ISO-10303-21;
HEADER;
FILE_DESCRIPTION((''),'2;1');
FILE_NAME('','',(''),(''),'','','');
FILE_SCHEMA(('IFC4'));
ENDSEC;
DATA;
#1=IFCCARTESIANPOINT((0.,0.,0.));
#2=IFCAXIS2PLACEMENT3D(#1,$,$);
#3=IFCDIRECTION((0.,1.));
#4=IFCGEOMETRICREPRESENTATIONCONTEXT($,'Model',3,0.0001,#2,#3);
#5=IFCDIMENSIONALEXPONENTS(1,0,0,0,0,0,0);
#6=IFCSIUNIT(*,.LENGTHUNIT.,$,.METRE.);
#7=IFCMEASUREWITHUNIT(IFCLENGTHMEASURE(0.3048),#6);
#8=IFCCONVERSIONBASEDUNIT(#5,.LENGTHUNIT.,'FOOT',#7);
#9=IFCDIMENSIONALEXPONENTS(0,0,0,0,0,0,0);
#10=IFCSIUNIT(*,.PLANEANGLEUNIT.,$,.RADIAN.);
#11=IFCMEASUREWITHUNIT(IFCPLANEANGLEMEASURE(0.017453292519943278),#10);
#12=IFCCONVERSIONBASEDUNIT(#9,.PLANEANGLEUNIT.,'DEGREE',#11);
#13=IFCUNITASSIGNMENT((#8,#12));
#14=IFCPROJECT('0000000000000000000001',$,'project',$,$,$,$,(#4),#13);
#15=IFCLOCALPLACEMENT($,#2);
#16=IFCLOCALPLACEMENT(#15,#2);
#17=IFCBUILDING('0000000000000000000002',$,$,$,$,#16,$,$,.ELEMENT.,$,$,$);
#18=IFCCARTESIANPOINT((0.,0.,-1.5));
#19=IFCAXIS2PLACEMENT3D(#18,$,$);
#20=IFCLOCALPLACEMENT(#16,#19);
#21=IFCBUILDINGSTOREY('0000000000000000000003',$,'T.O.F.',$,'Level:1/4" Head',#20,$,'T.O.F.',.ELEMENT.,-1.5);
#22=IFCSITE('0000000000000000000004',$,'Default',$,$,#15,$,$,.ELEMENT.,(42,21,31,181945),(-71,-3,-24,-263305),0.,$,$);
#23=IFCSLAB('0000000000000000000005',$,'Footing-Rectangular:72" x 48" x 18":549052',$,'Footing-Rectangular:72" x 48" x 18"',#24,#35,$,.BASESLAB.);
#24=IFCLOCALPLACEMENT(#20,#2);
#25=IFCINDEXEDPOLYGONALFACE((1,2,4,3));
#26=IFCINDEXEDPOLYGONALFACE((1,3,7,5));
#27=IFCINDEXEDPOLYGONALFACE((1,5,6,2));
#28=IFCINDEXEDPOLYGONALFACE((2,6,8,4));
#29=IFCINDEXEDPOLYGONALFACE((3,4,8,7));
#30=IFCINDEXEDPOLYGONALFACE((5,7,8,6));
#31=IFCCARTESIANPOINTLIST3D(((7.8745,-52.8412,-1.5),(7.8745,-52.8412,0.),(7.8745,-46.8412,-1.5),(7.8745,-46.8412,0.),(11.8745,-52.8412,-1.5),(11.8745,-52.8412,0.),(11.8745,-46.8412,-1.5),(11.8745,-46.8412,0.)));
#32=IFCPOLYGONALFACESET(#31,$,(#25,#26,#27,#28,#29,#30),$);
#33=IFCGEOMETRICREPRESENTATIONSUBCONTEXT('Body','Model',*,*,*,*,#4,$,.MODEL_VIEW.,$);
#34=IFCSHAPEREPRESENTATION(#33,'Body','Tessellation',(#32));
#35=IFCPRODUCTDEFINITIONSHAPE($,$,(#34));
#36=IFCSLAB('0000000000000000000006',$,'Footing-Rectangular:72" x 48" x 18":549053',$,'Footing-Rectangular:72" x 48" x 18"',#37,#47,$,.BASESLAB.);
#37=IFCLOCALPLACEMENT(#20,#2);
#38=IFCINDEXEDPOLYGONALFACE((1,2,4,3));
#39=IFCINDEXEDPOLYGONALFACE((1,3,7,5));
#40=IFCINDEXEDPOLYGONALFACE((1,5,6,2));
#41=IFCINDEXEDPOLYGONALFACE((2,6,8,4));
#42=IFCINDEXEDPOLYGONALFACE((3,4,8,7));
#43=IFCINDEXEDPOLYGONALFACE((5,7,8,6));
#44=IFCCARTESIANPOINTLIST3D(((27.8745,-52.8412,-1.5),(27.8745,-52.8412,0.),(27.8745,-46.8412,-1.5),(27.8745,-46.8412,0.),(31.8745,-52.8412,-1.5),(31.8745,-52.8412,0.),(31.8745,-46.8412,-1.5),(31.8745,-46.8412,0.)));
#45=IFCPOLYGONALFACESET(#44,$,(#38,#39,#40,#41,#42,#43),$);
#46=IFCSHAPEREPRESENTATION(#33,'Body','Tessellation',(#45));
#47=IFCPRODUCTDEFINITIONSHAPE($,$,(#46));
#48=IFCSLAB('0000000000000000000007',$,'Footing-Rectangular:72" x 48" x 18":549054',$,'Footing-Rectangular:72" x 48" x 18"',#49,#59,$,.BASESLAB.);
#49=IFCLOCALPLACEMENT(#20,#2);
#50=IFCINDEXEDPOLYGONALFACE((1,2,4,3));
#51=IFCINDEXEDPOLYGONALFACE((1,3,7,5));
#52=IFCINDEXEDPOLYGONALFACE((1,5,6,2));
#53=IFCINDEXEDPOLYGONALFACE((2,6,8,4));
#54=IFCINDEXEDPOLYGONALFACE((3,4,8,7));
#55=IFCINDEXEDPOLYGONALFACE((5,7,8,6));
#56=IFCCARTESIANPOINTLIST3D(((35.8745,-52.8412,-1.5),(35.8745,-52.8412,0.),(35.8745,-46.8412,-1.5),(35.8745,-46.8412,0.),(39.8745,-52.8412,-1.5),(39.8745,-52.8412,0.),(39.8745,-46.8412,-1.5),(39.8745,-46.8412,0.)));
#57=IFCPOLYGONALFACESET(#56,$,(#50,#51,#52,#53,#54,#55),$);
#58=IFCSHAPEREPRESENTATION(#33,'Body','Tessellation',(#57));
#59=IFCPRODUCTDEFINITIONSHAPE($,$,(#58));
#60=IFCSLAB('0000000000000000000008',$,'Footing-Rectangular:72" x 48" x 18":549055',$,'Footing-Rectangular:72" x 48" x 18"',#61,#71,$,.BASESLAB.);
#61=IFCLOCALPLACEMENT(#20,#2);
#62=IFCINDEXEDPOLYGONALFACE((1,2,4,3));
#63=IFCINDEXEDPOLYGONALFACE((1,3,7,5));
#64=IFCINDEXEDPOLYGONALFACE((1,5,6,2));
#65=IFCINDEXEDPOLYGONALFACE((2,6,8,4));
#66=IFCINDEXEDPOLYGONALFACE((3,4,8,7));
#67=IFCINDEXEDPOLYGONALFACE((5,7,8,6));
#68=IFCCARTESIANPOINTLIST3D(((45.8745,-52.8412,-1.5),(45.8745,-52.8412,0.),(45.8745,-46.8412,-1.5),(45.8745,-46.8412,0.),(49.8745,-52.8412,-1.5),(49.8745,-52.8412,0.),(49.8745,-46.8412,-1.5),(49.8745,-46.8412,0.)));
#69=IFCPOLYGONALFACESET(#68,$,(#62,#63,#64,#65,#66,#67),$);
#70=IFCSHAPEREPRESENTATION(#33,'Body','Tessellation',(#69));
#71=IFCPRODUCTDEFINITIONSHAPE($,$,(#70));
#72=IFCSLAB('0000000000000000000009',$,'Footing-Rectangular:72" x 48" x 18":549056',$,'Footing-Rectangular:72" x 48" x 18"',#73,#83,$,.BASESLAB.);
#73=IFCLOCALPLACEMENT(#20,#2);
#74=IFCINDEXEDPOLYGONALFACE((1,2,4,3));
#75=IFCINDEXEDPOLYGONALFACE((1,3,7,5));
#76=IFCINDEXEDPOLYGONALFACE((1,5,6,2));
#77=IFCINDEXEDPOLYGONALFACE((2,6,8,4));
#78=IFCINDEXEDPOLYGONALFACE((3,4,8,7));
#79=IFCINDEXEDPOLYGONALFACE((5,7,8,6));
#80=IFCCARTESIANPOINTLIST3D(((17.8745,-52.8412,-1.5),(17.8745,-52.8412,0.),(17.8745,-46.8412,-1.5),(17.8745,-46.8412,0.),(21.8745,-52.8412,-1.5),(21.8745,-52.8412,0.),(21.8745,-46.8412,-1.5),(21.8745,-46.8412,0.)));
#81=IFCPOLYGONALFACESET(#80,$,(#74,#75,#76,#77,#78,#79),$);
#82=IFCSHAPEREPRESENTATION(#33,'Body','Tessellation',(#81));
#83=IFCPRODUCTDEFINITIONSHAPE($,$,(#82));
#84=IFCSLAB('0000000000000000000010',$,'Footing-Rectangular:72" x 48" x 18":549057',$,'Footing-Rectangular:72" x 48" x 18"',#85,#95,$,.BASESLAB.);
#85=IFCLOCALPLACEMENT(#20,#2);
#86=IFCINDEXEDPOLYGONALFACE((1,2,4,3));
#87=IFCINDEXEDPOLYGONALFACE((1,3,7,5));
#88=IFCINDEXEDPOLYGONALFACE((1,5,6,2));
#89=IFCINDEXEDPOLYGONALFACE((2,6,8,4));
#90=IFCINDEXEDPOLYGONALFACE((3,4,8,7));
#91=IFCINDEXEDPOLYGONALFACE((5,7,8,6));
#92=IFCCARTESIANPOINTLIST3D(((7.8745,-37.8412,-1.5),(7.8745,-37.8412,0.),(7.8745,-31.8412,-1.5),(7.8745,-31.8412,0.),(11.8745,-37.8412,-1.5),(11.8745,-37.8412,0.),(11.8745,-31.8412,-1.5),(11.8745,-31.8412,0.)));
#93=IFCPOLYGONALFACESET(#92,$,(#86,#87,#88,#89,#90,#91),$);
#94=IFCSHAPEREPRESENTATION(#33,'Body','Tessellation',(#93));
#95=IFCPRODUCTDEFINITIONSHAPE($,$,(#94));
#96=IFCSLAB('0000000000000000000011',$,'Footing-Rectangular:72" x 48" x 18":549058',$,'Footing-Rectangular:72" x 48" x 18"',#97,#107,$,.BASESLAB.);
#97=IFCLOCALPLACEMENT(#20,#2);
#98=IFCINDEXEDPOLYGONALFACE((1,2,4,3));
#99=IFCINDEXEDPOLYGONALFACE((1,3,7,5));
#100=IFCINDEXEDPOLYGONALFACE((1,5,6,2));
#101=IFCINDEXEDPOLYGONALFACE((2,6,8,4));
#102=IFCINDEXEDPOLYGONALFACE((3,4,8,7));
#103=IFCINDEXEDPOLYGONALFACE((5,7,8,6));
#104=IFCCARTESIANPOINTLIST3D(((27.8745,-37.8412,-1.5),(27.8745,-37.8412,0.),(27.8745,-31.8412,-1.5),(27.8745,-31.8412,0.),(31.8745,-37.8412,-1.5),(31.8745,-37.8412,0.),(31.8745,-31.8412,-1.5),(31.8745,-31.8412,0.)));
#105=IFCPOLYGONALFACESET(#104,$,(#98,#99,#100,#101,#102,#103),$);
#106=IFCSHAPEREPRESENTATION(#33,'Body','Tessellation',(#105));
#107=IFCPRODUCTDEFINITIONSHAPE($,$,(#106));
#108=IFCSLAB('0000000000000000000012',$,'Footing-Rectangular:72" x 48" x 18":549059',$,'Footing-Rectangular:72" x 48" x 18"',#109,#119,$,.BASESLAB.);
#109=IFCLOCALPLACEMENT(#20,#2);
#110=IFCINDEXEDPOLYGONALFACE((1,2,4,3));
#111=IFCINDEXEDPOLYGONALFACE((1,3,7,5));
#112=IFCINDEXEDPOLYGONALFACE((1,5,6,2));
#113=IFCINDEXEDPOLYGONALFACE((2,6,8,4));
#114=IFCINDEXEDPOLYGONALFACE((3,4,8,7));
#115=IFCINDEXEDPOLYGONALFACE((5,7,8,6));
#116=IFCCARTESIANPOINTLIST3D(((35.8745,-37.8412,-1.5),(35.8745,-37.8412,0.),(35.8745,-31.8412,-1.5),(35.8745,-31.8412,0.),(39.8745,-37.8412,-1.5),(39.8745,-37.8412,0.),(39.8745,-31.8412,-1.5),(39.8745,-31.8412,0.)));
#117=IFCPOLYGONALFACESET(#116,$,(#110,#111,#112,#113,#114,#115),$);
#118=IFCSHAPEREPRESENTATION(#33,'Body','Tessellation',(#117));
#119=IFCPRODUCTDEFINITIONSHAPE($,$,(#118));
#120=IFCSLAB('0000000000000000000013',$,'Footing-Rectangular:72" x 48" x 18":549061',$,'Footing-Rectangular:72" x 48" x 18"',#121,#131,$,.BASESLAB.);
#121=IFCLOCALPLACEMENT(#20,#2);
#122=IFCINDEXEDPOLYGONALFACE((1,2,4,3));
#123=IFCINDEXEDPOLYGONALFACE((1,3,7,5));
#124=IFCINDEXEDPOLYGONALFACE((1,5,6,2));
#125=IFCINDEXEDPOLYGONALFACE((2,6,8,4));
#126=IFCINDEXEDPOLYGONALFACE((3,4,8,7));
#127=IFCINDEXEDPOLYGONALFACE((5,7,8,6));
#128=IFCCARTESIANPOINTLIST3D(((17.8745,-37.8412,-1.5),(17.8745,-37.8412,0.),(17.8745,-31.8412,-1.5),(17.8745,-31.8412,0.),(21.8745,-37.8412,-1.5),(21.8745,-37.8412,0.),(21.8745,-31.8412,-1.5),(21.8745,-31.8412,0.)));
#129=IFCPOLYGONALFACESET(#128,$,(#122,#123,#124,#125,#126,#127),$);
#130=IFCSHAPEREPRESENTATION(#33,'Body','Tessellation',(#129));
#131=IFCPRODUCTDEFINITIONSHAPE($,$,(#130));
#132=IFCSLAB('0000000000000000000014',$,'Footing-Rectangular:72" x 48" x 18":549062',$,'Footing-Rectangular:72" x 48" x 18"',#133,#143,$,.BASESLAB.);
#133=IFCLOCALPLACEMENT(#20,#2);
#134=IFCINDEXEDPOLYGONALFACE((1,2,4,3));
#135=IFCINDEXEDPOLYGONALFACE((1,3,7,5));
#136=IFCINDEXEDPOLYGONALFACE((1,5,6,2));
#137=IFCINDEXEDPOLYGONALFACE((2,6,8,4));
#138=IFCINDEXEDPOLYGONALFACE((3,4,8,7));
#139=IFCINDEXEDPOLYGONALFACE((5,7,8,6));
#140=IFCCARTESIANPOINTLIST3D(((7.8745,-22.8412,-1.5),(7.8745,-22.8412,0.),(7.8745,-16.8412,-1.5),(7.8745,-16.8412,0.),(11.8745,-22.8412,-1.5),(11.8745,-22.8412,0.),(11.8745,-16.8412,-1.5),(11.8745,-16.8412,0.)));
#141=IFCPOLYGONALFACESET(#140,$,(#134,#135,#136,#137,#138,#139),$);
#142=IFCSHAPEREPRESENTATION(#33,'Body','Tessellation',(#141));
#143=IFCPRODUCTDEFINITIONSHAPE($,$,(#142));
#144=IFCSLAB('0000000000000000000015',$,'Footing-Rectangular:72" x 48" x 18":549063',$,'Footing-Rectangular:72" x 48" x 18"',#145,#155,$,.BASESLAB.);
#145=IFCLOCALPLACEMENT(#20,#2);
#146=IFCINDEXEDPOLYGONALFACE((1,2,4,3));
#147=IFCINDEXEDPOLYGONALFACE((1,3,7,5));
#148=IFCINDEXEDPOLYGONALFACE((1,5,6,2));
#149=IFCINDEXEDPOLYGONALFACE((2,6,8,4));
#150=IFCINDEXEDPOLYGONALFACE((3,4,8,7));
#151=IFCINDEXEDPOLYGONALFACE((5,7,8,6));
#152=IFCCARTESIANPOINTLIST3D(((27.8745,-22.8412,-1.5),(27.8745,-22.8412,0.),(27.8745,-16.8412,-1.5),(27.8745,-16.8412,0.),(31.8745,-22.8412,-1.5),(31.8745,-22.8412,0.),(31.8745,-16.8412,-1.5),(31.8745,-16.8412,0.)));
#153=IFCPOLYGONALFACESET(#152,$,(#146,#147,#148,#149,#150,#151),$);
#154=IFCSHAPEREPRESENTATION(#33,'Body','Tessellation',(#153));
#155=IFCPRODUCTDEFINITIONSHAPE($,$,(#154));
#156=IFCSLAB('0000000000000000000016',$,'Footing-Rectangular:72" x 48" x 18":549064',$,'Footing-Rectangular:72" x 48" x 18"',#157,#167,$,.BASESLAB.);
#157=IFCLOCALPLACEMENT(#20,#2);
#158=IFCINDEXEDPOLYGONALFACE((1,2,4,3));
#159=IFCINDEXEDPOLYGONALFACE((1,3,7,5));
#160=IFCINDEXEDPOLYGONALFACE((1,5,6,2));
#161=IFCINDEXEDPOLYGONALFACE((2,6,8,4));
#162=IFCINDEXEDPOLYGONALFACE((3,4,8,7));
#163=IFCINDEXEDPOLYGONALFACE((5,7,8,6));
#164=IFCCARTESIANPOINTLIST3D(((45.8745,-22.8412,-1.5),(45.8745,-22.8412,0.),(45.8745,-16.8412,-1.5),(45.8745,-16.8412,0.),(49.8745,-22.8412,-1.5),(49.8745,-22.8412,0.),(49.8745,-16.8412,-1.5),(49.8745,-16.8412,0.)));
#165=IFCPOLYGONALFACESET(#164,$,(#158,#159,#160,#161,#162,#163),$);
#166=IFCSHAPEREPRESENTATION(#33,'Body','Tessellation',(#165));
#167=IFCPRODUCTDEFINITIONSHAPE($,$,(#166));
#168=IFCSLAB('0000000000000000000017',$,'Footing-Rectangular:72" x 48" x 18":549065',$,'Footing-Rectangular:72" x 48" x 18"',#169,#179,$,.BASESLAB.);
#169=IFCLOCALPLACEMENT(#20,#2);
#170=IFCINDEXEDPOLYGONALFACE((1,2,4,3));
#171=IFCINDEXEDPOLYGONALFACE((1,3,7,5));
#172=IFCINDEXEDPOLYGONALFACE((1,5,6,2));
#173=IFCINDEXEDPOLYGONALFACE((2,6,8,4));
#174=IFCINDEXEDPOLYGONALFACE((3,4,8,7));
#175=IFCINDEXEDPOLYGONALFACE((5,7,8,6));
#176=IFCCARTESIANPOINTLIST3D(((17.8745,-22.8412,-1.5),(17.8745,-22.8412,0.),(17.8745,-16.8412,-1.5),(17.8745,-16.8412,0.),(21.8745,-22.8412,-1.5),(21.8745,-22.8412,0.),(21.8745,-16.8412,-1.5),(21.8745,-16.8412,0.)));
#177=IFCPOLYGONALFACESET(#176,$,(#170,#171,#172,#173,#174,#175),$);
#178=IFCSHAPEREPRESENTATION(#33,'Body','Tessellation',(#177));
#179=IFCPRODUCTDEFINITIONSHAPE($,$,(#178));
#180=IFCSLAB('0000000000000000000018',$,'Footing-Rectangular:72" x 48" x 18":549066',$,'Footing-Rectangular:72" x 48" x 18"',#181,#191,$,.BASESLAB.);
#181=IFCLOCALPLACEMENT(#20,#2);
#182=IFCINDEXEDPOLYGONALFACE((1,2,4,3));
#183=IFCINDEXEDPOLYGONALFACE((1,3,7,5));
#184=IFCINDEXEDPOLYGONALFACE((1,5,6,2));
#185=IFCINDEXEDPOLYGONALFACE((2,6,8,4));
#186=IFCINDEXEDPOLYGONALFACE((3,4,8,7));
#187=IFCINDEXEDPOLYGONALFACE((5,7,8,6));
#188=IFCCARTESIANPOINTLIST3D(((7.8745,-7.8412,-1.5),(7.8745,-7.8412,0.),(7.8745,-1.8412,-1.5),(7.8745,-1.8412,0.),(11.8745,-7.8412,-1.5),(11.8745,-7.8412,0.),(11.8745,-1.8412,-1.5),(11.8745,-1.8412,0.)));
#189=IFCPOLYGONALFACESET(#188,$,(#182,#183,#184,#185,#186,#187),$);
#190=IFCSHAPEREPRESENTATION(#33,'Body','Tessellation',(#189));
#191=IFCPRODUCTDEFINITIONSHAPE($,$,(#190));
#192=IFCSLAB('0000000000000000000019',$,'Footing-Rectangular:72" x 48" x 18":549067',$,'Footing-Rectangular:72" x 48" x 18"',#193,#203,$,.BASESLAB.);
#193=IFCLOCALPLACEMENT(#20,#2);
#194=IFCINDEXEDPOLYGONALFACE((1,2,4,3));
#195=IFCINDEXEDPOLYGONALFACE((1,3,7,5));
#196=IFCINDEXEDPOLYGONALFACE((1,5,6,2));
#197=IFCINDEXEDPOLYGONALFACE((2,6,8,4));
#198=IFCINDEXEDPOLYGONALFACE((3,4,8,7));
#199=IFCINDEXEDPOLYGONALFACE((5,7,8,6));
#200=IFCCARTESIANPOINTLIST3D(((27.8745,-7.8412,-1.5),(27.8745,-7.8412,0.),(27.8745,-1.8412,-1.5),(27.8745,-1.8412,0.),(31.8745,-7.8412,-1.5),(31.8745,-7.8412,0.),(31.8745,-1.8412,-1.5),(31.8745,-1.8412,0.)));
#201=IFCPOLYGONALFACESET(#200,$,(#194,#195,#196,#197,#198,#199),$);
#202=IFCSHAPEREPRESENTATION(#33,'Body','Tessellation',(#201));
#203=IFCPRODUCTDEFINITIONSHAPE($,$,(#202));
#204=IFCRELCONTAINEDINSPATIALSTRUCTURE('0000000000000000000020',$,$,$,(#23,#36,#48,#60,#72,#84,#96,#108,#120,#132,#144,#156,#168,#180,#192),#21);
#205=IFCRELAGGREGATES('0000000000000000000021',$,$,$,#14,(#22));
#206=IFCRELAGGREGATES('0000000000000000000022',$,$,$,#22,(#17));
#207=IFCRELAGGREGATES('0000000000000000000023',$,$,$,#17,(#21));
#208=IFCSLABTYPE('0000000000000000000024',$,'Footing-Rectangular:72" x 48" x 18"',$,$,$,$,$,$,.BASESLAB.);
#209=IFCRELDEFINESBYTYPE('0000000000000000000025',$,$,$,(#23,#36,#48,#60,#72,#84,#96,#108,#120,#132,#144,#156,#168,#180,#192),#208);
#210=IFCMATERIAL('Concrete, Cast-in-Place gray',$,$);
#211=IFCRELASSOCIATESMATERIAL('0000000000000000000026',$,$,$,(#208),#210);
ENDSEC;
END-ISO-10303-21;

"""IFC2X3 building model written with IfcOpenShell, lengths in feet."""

from ifc_helpers import new_model, entity, si_unit, converted_unit, direction, frame, frame_2d, origin, origin_2d_with_axis, place, context, subcontext, project, spatial, rectangle, extrude, material, type_object, element, save


model = new_model("IFC2X3")

# Units and contexts
model_context = context("Model", 3, precision=0.0001, world=origin(), true_north=direction((0.0, 1.0)))
body_context = subcontext(model_context, "Body", "Model", "MODEL_VIEW")
ifc_project = project(units=[converted_unit("LENGTHUNIT", "FOOT", entity("IfcLengthMeasure", 0.3048), si_unit("LENGTHUNIT", "METRE"), dimensions=[1, 0, 0, 0, 0, 0, 0]), converted_unit("PLANEANGLEUNIT", "DEGREE", entity("IfcPlaneAngleMeasure", 0.017453292519943278), si_unit("PLANEANGLEUNIT", "RADIAN"), dimensions=[0, 0, 0, 0, 0, 0, 0])], contexts=[model_context])

# Site, building, storey
site_placement = place(None, origin())
site = spatial("IfcSite", under=ifc_project, at=site_placement, Name="Default", CompositionType="ELEMENT", RefLatitude=(42, 21, 31, 181945), RefLongitude=(-71, -3, -24, -263305), RefElevation=0.0)
building_placement = place(site_placement, origin())
building = spatial("IfcBuilding", under=site, at=building_placement, CompositionType="ELEMENT")
storey_placement = place(building_placement, frame((0.0, 0.0, -1.5)))
storey = spatial("IfcBuildingStorey", under=building, at=storey_placement, Name="T.O.F.", ObjectType="Level:1/4\" Head", LongName="T.O.F.", CompositionType="ELEMENT", Elevation=-1.5)

# Slabs
ifc_material = material(Name="Concrete, Cast-in-Place gray")
slab_type = type_object("IfcSlabType", Name="Footing-Rectangular:72\" x 48\" x 18\"", PredefinedType="BASESLAB", material=ifc_material)
slab_1_placement = place(storey_placement, origin())
element("IfcSlab", 1, at=slab_1_placement, inside=storey, type_object=slab_type, Name="Footing-Rectangular:72\" x 48\" x 18\":549052", ObjectType="Footing-Rectangular:72\" x 48\" x 18\"", PredefinedType="BASESLAB", context=body_context, shape_type="SweptSolid", body=[
    extrude(rectangle(XDim=4.0, YDim=6.0, at=origin_2d_with_axis()), frame((9.8745, -49.8412, -1.5), z_axis=(0.0, 0.0, 1.0), x_axis=(-1.0, 0.0, 0.0)), (0.0, 0.0, 1.0), 1.5),
])
slab_2_placement = place(storey_placement, origin())
element("IfcSlab", 2, at=slab_2_placement, inside=storey, type_object=slab_type, Name="Footing-Rectangular:72\" x 48\" x 18\":549053", ObjectType="Footing-Rectangular:72\" x 48\" x 18\"", PredefinedType="BASESLAB", context=body_context, shape_type="SweptSolid", body=[
    extrude(rectangle(XDim=4.0, YDim=6.0, at=frame_2d((0.0, 0.0), x_axis=(1.0, 0.0))), frame((29.8745, -49.8412, -1.5), z_axis=(0.0, 0.0, 1.0), x_axis=(-1.0, 0.0, 0.0)), (0.0, 0.0, 1.0), 1.5),
])
slab_3_placement = place(storey_placement, origin())
element("IfcSlab", 3, at=slab_3_placement, inside=storey, type_object=slab_type, Name="Footing-Rectangular:72\" x 48\" x 18\":549054", ObjectType="Footing-Rectangular:72\" x 48\" x 18\"", PredefinedType="BASESLAB", context=body_context, shape_type="SweptSolid", body=[
    extrude(rectangle(XDim=4.0, YDim=6.0, at=frame_2d((0.0, 0.0), x_axis=(1.0, 0.0))), frame((37.8745, -49.8412, -1.5), z_axis=(0.0, 0.0, 1.0), x_axis=(-1.0, 0.0, 0.0)), (0.0, 0.0, 1.0), 1.5),
])
slab_4_placement = place(storey_placement, origin())
element("IfcSlab", 4, at=slab_4_placement, inside=storey, type_object=slab_type, Name="Footing-Rectangular:72\" x 48\" x 18\":549055", ObjectType="Footing-Rectangular:72\" x 48\" x 18\"", PredefinedType="BASESLAB", context=body_context, shape_type="SweptSolid", body=[
    extrude(rectangle(XDim=4.0, YDim=6.0, at=frame_2d((0.0, 0.0), x_axis=(1.0, 0.0))), frame((47.8745, -49.8412, -1.5), z_axis=(0.0, 0.0, 1.0), x_axis=(-1.0, 0.0, 0.0)), (0.0, 0.0, 1.0), 1.5),
])
slab_5_placement = place(storey_placement, origin())
element("IfcSlab", 5, at=slab_5_placement, inside=storey, type_object=slab_type, Name="Footing-Rectangular:72\" x 48\" x 18\":549056", ObjectType="Footing-Rectangular:72\" x 48\" x 18\"", PredefinedType="BASESLAB", context=body_context, shape_type="SweptSolid", body=[
    extrude(rectangle(XDim=4.0, YDim=6.0, at=frame_2d((0.0, 0.0), x_axis=(1.0, 0.0))), frame((19.8745, -49.8412, -1.5), z_axis=(0.0, 0.0, 1.0), x_axis=(-1.0, 0.0, 0.0)), (0.0, 0.0, 1.0), 1.5),
])
slab_6_placement = place(storey_placement, origin())
element("IfcSlab", 6, at=slab_6_placement, inside=storey, type_object=slab_type, Name="Footing-Rectangular:72\" x 48\" x 18\":549057", ObjectType="Footing-Rectangular:72\" x 48\" x 18\"", PredefinedType="BASESLAB", context=body_context, shape_type="SweptSolid", body=[
    extrude(rectangle(XDim=4.0, YDim=6.0, at=origin_2d_with_axis()), frame((9.8745, -34.8412, -1.5), z_axis=(0.0, 0.0, 1.0), x_axis=(-1.0, 0.0, 0.0)), (0.0, 0.0, 1.0), 1.5),
])
slab_7_placement = place(storey_placement, origin())
element("IfcSlab", 7, at=slab_7_placement, inside=storey, type_object=slab_type, Name="Footing-Rectangular:72\" x 48\" x 18\":549058", ObjectType="Footing-Rectangular:72\" x 48\" x 18\"", PredefinedType="BASESLAB", context=body_context, shape_type="SweptSolid", body=[
    extrude(rectangle(XDim=4.0, YDim=6.0, at=frame_2d((0.0, 0.0), x_axis=(1.0, 0.0))), frame((29.8745, -34.8412, -1.5), z_axis=(0.0, 0.0, 1.0), x_axis=(-1.0, 0.0, 0.0)), (0.0, 0.0, 1.0), 1.5),
])
slab_8_placement = place(storey_placement, origin())
element("IfcSlab", 8, at=slab_8_placement, inside=storey, type_object=slab_type, Name="Footing-Rectangular:72\" x 48\" x 18\":549059", ObjectType="Footing-Rectangular:72\" x 48\" x 18\"", PredefinedType="BASESLAB", context=body_context, shape_type="SweptSolid", body=[
    extrude(rectangle(XDim=4.0, YDim=6.0, at=frame_2d((0.0, 0.0), x_axis=(1.0, 0.0))), frame((37.8745, -34.8412, -1.5), z_axis=(0.0, 0.0, 1.0), x_axis=(-1.0, 0.0, 0.0)), (0.0, 0.0, 1.0), 1.5),
])
slab_9_placement = place(storey_placement, origin())
element("IfcSlab", 9, at=slab_9_placement, inside=storey, type_object=slab_type, Name="Footing-Rectangular:72\" x 48\" x 18\":549061", ObjectType="Footing-Rectangular:72\" x 48\" x 18\"", PredefinedType="BASESLAB", context=body_context, shape_type="SweptSolid", body=[
    extrude(rectangle(XDim=4.0, YDim=6.0, at=frame_2d((0.0, 0.0), x_axis=(1.0, 0.0))), frame((19.8745, -34.8412, -1.5), z_axis=(0.0, 0.0, 1.0), x_axis=(-1.0, 0.0, 0.0)), (0.0, 0.0, 1.0), 1.5),
])
slab_10_placement = place(storey_placement, origin())
element("IfcSlab", 10, at=slab_10_placement, inside=storey, type_object=slab_type, Name="Footing-Rectangular:72\" x 48\" x 18\":549062", ObjectType="Footing-Rectangular:72\" x 48\" x 18\"", PredefinedType="BASESLAB", context=body_context, shape_type="SweptSolid", body=[
    extrude(rectangle(XDim=4.0, YDim=6.0, at=origin_2d_with_axis()), frame((9.8745, -19.8412, -1.5), z_axis=(0.0, 0.0, 1.0), x_axis=(-1.0, 0.0, 0.0)), (0.0, 0.0, 1.0), 1.5),
])
slab_11_placement = place(storey_placement, origin())
element("IfcSlab", 11, at=slab_11_placement, inside=storey, type_object=slab_type, Name="Footing-Rectangular:72\" x 48\" x 18\":549063", ObjectType="Footing-Rectangular:72\" x 48\" x 18\"", PredefinedType="BASESLAB", context=body_context, shape_type="SweptSolid", body=[
    extrude(rectangle(XDim=4.0, YDim=6.0, at=frame_2d((0.0, 0.0), x_axis=(1.0, 0.0))), frame((29.8745, -19.8412, -1.5), z_axis=(0.0, 0.0, 1.0), x_axis=(-1.0, 0.0, 0.0)), (0.0, 0.0, 1.0), 1.5),
])
slab_12_placement = place(storey_placement, origin())
element("IfcSlab", 12, at=slab_12_placement, inside=storey, type_object=slab_type, Name="Footing-Rectangular:72\" x 48\" x 18\":549064", ObjectType="Footing-Rectangular:72\" x 48\" x 18\"", PredefinedType="BASESLAB", context=body_context, shape_type="SweptSolid", body=[
    extrude(rectangle(XDim=4.0, YDim=6.0, at=frame_2d((0.0, 0.0), x_axis=(1.0, 0.0))), frame((47.8745, -19.8412, -1.5), z_axis=(0.0, 0.0, 1.0), x_axis=(-1.0, 0.0, 0.0)), (0.0, 0.0, 1.0), 1.5),
])
slab_13_placement = place(storey_placement, origin())
element("IfcSlab", 13, at=slab_13_placement, inside=storey, type_object=slab_type, Name="Footing-Rectangular:72\" x 48\" x 18\":549065", ObjectType="Footing-Rectangular:72\" x 48\" x 18\"", PredefinedType="BASESLAB", context=body_context, shape_type="SweptSolid", body=[
    extrude(rectangle(XDim=4.0, YDim=6.0, at=frame_2d((0.0, 0.0), x_axis=(1.0, 0.0))), frame((19.8745, -19.8412, -1.5), z_axis=(0.0, 0.0, 1.0), x_axis=(-1.0, 0.0, 0.0)), (0.0, 0.0, 1.0), 1.5),
])
slab_14_placement = place(storey_placement, origin())
element("IfcSlab", 14, at=slab_14_placement, inside=storey, type_object=slab_type, Name="Footing-Rectangular:72\" x 48\" x 18\":549066", ObjectType="Footing-Rectangular:72\" x 48\" x 18\"", PredefinedType="BASESLAB", context=body_context, shape_type="SweptSolid", body=[
    extrude(rectangle(XDim=4.0, YDim=6.0, at=frame_2d((0.0, 0.0), x_axis=(1.0, 0.0))), frame((9.8745, -4.8412, -1.5), z_axis=(0.0, 0.0, 1.0), x_axis=(-1.0, 0.0, 0.0)), (0.0, 0.0, 1.0), 1.5),
])
slab_15_placement = place(storey_placement, origin())
element("IfcSlab", 15, at=slab_15_placement, inside=storey, type_object=slab_type, Name="Footing-Rectangular:72\" x 48\" x 18\":549067", ObjectType="Footing-Rectangular:72\" x 48\" x 18\"", PredefinedType="BASESLAB", context=body_context, shape_type="SweptSolid", body=[
    extrude(rectangle(XDim=4.0, YDim=6.0, at=frame_2d((0.0, 0.0), x_axis=(1.0, 0.0))), frame((29.8745, -4.8412, -1.5), z_axis=(0.0, 0.0, 1.0), x_axis=(-1.0, 0.0, 0.0)), (0.0, 0.0, 1.0), 1.5),
])

save(model, "model.ifc")
